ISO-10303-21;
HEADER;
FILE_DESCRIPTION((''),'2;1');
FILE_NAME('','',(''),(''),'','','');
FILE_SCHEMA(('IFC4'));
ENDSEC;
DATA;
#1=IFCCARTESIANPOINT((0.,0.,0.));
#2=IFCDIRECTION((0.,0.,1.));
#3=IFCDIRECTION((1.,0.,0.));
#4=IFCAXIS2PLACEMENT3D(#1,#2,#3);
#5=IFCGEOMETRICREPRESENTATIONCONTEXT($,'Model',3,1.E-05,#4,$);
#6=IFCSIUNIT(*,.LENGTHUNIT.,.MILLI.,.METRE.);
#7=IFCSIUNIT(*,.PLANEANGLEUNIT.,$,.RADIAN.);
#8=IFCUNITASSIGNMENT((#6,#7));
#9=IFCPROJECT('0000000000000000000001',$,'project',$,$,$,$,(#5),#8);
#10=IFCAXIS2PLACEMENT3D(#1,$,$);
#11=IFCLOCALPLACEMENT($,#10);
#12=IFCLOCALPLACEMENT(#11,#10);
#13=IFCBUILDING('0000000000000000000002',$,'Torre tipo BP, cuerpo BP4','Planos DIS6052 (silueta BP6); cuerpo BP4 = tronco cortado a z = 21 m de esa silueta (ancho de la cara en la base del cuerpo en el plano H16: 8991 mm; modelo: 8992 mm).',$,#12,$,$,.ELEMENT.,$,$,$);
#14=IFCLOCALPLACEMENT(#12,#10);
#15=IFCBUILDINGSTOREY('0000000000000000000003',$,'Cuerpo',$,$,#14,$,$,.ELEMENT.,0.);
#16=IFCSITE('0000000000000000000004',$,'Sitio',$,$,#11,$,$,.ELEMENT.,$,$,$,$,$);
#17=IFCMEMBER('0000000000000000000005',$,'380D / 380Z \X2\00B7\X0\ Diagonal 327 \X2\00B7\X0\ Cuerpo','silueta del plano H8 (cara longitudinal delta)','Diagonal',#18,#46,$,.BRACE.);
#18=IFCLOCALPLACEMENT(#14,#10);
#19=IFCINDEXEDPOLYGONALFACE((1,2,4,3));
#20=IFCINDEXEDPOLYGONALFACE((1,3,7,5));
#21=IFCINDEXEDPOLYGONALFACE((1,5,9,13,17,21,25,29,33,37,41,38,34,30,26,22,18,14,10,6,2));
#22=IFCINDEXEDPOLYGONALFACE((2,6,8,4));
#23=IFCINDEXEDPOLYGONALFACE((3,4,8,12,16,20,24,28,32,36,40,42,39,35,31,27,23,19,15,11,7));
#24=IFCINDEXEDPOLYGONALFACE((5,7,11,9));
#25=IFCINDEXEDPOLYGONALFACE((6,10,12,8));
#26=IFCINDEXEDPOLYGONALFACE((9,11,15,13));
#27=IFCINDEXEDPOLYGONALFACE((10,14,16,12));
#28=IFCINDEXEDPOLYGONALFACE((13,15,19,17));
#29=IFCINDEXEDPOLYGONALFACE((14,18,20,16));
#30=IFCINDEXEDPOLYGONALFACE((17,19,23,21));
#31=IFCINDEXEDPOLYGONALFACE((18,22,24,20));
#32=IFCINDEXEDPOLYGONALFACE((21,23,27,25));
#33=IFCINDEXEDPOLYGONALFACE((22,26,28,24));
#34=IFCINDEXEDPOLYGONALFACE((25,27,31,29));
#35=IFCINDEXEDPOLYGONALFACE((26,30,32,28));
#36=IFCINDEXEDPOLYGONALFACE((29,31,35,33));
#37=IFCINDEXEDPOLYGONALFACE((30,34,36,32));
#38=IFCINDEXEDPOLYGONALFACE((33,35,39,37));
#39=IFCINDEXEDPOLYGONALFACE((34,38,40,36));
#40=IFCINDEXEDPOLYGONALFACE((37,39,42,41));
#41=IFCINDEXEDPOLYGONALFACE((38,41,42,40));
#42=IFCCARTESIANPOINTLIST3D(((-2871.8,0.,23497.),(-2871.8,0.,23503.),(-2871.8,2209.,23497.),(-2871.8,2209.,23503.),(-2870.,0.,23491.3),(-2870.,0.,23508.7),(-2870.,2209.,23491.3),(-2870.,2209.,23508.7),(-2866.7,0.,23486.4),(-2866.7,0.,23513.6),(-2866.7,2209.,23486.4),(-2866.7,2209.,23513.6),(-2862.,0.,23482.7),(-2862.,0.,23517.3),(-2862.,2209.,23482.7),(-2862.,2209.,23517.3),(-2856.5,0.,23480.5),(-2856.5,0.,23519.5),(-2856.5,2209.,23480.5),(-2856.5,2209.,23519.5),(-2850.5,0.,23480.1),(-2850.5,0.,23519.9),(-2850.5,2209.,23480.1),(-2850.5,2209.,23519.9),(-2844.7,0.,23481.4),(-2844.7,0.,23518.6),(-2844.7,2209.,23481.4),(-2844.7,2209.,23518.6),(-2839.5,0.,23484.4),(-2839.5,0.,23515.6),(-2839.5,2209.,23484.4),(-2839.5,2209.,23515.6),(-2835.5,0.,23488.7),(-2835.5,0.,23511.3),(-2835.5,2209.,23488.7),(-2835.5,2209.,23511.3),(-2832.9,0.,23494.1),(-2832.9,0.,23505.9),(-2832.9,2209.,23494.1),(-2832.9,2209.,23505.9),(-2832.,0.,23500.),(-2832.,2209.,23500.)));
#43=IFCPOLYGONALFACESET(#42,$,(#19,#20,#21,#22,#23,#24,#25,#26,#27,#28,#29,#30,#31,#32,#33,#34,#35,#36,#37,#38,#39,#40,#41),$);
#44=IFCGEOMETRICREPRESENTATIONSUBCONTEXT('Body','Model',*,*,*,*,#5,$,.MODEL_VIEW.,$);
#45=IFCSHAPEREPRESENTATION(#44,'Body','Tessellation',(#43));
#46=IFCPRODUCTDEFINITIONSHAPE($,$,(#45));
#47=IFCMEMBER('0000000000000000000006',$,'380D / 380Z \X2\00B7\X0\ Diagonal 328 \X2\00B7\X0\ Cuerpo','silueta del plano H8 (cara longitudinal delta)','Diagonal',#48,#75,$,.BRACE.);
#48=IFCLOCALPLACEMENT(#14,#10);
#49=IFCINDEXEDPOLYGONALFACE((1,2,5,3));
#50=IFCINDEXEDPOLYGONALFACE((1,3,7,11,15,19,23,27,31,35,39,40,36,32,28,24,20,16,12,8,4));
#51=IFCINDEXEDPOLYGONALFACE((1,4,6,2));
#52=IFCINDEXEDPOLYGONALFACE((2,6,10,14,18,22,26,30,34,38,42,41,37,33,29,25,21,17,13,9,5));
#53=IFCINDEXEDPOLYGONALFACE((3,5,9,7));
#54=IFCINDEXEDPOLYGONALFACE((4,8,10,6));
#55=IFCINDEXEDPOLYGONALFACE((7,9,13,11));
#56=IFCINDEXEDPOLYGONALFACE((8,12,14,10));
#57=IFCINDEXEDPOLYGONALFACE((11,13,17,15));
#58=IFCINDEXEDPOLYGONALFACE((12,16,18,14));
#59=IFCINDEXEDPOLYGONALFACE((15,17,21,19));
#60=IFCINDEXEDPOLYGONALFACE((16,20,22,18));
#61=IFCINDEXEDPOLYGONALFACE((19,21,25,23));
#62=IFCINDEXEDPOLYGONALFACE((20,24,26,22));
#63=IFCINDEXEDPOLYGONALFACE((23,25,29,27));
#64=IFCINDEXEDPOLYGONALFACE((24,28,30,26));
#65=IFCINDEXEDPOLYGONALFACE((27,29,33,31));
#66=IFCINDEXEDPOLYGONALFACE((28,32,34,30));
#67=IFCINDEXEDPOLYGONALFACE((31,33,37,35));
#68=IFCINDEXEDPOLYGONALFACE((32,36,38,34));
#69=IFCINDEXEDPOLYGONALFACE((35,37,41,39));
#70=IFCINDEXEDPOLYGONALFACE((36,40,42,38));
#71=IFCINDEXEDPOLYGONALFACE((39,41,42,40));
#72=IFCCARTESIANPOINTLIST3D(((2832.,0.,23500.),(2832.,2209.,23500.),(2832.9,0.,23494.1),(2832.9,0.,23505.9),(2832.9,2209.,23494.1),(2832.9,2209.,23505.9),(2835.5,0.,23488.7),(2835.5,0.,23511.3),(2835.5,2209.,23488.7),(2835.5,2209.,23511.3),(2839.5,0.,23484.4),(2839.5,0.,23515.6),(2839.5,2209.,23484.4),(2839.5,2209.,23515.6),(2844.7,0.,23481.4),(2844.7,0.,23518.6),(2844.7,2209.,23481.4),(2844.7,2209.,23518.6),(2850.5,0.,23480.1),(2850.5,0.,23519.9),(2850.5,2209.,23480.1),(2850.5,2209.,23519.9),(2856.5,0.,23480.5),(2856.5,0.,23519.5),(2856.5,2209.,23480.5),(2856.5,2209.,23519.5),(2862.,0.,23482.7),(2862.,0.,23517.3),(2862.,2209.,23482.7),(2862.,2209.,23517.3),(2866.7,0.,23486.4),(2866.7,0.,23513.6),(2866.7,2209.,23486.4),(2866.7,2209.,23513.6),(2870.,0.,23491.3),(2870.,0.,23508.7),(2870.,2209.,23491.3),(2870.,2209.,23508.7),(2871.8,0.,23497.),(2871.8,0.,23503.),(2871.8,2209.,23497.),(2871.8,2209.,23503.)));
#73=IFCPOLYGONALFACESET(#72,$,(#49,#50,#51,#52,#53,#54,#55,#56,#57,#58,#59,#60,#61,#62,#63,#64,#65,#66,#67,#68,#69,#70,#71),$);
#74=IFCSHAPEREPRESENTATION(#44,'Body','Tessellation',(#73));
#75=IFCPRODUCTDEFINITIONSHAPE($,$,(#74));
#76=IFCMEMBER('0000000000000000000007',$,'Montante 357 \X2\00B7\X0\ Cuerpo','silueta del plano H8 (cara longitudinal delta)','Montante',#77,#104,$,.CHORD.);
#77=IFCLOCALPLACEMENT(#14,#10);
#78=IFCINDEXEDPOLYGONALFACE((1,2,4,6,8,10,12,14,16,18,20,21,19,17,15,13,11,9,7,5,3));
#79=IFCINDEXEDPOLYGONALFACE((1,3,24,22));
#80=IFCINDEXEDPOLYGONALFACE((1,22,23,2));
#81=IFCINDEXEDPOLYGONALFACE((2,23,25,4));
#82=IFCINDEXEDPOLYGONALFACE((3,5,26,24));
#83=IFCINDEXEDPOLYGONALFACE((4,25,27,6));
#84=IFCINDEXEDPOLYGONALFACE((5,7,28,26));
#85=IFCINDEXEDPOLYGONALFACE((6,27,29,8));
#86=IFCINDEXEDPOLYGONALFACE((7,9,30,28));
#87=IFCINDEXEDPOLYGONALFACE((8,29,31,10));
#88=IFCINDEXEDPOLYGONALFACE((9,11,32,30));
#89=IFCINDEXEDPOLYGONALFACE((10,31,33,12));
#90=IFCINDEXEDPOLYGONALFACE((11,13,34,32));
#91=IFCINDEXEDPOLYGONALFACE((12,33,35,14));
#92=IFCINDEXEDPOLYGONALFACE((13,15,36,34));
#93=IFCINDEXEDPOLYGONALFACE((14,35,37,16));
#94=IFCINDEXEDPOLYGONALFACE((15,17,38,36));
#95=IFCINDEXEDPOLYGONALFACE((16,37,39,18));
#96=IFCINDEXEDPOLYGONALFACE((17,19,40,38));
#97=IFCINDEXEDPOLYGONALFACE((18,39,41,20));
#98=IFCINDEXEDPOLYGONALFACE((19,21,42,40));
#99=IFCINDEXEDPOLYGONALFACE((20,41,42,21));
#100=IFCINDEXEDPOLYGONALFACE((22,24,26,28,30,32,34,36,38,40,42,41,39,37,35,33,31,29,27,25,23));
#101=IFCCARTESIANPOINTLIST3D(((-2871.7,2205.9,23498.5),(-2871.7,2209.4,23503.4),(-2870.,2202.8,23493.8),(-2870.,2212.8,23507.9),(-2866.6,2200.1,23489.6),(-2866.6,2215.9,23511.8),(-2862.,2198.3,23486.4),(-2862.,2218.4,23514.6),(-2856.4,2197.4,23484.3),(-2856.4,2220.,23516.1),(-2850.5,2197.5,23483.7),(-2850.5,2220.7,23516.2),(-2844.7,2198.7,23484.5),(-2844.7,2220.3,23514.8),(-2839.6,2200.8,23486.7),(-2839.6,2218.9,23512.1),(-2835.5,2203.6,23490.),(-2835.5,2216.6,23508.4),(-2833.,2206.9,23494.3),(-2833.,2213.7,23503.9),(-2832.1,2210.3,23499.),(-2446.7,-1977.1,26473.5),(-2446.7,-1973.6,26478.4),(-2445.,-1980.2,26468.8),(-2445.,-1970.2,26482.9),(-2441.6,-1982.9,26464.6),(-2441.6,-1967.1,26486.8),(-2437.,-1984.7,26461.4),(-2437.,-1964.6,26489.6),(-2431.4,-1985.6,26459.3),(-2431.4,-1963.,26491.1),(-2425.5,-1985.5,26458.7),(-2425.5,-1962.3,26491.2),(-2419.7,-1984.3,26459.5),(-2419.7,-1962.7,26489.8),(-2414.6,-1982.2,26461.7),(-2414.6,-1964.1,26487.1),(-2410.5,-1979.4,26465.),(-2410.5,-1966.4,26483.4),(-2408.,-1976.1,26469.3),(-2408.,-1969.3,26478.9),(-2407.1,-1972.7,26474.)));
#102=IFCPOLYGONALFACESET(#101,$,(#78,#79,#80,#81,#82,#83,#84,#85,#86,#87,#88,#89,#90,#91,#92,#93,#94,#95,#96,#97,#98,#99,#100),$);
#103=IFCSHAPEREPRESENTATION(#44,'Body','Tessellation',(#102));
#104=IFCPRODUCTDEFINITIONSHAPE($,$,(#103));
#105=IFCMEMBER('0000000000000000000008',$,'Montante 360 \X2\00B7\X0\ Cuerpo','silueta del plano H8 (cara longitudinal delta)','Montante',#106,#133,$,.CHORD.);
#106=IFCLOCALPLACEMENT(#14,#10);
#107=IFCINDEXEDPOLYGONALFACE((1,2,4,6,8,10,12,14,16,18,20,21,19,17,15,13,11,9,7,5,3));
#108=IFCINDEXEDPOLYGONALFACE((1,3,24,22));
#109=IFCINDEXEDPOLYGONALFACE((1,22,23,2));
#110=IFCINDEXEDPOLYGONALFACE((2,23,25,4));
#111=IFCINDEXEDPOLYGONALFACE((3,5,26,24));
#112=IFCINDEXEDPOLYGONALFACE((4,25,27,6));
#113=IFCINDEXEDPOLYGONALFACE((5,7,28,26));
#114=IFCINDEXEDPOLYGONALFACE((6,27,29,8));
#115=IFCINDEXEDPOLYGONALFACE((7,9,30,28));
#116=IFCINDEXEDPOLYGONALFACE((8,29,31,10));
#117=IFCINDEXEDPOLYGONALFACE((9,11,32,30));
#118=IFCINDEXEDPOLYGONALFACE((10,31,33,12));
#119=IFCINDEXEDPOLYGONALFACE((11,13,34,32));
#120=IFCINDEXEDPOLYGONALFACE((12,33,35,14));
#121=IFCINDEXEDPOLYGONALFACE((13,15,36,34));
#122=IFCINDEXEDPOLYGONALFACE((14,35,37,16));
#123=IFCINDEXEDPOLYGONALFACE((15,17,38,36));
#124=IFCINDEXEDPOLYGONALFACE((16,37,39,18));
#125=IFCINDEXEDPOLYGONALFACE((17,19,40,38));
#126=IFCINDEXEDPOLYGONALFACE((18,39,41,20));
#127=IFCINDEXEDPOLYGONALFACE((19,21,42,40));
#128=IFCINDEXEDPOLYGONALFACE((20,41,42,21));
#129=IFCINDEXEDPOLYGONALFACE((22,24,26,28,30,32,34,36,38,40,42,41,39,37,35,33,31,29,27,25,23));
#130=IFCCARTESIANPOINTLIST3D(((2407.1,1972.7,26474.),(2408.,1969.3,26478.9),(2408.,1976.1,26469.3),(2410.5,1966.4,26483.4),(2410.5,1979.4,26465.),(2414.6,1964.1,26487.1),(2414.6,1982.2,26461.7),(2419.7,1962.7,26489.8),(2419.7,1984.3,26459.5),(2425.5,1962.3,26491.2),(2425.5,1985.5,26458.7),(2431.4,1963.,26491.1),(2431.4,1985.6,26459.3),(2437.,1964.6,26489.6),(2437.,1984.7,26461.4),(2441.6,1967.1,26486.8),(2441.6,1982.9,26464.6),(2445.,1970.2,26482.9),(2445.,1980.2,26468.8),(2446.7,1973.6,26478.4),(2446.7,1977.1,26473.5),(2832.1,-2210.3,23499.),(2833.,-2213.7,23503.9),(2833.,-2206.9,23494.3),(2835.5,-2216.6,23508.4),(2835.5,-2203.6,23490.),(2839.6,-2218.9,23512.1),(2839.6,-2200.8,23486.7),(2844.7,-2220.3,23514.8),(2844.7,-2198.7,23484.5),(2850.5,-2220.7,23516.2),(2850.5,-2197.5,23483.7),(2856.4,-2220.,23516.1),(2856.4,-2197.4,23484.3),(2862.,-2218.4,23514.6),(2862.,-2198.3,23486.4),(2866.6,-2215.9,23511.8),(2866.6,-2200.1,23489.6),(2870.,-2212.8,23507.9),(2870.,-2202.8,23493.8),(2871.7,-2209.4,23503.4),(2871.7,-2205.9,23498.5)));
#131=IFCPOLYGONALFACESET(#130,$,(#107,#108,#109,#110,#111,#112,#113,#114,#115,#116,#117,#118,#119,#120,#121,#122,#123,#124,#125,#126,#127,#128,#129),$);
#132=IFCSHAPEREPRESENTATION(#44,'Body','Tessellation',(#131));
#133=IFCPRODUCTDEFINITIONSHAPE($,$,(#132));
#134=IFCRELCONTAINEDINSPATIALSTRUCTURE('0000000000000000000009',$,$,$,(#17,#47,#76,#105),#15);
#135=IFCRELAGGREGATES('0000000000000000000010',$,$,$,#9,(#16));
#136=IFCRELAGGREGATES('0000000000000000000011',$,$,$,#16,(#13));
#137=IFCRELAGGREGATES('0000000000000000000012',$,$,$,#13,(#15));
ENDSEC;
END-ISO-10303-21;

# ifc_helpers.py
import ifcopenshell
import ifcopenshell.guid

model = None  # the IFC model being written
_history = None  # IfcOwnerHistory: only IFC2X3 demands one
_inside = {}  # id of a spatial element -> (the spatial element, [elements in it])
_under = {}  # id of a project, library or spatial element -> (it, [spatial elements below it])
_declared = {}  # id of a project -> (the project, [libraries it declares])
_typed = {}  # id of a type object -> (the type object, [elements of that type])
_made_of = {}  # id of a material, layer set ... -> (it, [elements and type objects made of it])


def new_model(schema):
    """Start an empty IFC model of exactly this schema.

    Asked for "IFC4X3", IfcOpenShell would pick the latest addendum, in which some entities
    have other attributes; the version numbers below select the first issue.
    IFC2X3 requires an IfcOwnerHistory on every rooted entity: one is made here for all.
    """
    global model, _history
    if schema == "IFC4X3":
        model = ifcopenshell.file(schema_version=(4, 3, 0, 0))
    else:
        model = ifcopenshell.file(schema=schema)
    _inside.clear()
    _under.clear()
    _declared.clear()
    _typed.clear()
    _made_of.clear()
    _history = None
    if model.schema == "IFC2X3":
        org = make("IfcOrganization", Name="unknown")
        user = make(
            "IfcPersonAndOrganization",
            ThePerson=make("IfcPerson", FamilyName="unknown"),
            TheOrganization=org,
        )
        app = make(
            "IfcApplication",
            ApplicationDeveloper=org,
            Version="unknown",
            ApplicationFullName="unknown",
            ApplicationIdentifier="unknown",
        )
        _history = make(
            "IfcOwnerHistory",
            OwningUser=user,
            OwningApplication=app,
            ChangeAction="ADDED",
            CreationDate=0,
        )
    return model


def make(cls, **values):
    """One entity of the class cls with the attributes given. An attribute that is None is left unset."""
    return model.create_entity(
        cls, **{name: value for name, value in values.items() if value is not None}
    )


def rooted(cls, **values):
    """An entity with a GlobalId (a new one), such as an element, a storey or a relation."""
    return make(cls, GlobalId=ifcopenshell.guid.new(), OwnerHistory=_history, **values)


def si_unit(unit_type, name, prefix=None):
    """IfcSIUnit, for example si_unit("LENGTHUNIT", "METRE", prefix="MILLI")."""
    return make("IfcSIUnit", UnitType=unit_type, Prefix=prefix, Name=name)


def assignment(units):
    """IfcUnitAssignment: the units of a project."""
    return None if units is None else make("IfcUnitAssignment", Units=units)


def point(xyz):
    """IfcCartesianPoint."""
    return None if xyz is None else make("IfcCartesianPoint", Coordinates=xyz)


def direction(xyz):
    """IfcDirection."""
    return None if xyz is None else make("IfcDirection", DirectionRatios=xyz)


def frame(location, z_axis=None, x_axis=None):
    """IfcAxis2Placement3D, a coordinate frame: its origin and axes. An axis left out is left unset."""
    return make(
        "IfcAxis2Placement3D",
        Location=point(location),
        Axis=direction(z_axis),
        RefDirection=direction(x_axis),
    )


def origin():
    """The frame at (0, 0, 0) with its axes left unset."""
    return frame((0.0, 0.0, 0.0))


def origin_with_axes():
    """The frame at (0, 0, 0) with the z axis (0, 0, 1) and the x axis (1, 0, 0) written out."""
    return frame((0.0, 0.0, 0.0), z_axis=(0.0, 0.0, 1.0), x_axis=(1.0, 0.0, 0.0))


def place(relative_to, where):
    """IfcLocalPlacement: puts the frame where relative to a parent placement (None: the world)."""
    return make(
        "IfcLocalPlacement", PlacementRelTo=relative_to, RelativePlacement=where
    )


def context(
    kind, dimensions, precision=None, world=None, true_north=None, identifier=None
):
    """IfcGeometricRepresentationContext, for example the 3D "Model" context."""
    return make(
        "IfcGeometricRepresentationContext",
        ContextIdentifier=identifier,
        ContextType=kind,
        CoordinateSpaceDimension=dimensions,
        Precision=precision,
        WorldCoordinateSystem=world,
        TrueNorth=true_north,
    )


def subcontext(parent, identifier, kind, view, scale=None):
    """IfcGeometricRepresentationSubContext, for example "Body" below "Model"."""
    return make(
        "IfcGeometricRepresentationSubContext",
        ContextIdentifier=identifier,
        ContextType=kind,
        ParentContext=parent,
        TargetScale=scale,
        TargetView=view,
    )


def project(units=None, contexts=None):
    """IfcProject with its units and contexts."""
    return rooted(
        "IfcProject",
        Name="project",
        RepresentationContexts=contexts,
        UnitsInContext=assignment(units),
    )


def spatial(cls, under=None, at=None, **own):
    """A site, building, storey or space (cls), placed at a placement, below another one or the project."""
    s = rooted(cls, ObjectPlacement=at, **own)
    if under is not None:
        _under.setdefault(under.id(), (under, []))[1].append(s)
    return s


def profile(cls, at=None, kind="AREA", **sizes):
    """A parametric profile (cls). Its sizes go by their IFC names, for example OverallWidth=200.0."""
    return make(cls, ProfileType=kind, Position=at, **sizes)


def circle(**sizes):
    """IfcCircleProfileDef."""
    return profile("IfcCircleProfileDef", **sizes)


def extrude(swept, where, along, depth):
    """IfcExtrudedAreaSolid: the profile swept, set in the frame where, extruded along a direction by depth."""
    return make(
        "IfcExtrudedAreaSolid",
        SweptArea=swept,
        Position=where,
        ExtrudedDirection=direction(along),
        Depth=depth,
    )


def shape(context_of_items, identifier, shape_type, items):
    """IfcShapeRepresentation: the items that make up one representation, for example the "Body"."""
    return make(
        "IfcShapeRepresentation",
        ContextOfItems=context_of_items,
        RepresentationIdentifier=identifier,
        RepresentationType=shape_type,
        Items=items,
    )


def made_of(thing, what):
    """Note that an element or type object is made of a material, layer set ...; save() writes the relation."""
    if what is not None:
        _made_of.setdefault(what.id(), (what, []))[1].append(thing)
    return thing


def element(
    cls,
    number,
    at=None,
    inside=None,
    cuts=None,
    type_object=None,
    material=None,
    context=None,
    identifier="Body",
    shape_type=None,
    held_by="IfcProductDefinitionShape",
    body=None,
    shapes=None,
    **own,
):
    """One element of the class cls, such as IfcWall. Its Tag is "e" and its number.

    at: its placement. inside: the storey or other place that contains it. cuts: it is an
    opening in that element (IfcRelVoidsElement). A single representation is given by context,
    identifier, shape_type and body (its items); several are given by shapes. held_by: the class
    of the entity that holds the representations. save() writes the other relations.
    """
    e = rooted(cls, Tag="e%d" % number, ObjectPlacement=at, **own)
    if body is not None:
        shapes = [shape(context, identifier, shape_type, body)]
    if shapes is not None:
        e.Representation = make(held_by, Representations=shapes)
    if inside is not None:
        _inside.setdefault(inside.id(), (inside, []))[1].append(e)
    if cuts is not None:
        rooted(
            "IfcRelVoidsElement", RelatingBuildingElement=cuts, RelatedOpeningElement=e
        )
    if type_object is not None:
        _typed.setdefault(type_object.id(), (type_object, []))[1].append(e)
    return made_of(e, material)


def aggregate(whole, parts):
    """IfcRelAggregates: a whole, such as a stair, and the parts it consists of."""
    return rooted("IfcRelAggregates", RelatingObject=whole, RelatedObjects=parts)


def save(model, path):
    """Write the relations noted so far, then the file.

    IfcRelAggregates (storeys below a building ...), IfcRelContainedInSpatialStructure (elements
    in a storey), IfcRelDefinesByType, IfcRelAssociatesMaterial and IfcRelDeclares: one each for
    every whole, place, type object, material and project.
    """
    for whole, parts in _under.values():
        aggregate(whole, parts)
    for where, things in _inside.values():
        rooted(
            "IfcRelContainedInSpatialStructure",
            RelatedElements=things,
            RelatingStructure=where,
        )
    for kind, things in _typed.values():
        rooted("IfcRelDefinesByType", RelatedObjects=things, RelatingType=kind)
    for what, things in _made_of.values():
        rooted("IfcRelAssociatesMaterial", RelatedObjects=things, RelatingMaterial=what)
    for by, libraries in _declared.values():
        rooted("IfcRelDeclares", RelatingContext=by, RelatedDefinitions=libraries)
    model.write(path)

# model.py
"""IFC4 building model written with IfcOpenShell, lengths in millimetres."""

from ifc_helpers import new_model, si_unit, frame, origin, origin_with_axes, place, context, subcontext, project, spatial, circle, extrude, element, save


model = new_model("IFC4")

# Units and contexts
model_context = context("Model", 3, precision=1e-05, world=origin_with_axes())
body_context = subcontext(model_context, "Body", "Model", "MODEL_VIEW")
ifc_project = project(units=[si_unit("LENGTHUNIT", "METRE", prefix="MILLI"), si_unit("PLANEANGLEUNIT", "RADIAN")], contexts=[model_context])

# Site, building, storey
site_placement = place(None, origin())
site = spatial("IfcSite", under=ifc_project, at=site_placement, Name="Sitio", CompositionType="ELEMENT")
building_placement = place(site_placement, origin())
building = spatial("IfcBuilding", under=site, at=building_placement, Name="Torre tipo BP, cuerpo BP4", Description="Planos DIS6052 (silueta BP6); cuerpo BP4 = tronco cortado a z = 21 m de esa silueta (ancho de la cara en la base del cuerpo en el plano H16: 8991 mm; modelo: 8992 mm).", CompositionType="ELEMENT")
storey_placement = place(building_placement, origin())
storey = spatial("IfcBuildingStorey", under=building, at=storey_placement, Name="Cuerpo", CompositionType="ELEMENT", Elevation=0.0)

# Members
for number, where, z_axis, x_axis, name in (
    (1, (-2852.0, 2209.0, 23500.0), (0.0, -1.0, 0.0), (1.0, 0.0, 0.0), "380D / 380Z · Diagonal 327 · Cuerpo"),
    (2, (2852.0, 2209.0, 23500.0), (0.0, -1.0, 0.0), (-1.0, 0.0, 0.0), "380D / 380Z · Diagonal 328 · Cuerpo"),
):
    element("IfcMember", number, at=place(storey_placement, frame(where, z_axis=z_axis, x_axis=x_axis)), inside=storey, Name=name, Description="silueta del plano H8 (cara longitudinal delta)", ObjectType="Diagonal", PredefinedType="BRACE", context=body_context, shape_type="SweptSolid", body=[
        extrude(circle(Radius=20.0), None, (0.0, 0.0, 1.0), 2209.0),
    ])
for number, where, z_axis, x_axis, name in (
    (3, (-2427.0, -1974.0, 26475.0), (-0.082515, 0.812137, -0.577602), (0.99659, 0.067242, -0.047824), "Montante 357 · Cuerpo"),
    (4, (2427.0, 1974.0, 26475.0), (0.082515, -0.812137, -0.577602), (-0.99659, -0.067242, -0.047824), "Montante 360 · Cuerpo"),
):
    element("IfcMember", number, at=place(storey_placement, frame(where, z_axis=z_axis, x_axis=x_axis)), inside=storey, Name=name, Description="silueta del plano H8 (cara longitudinal delta)", ObjectType="Montante", PredefinedType="CHORD", context=body_context, shape_type="SweptSolid", body=[
        extrude(circle(Radius=20.0), None, (0.0, 0.0, 1.0), 5150.6),
    ])

save(model, "model.ifc")
